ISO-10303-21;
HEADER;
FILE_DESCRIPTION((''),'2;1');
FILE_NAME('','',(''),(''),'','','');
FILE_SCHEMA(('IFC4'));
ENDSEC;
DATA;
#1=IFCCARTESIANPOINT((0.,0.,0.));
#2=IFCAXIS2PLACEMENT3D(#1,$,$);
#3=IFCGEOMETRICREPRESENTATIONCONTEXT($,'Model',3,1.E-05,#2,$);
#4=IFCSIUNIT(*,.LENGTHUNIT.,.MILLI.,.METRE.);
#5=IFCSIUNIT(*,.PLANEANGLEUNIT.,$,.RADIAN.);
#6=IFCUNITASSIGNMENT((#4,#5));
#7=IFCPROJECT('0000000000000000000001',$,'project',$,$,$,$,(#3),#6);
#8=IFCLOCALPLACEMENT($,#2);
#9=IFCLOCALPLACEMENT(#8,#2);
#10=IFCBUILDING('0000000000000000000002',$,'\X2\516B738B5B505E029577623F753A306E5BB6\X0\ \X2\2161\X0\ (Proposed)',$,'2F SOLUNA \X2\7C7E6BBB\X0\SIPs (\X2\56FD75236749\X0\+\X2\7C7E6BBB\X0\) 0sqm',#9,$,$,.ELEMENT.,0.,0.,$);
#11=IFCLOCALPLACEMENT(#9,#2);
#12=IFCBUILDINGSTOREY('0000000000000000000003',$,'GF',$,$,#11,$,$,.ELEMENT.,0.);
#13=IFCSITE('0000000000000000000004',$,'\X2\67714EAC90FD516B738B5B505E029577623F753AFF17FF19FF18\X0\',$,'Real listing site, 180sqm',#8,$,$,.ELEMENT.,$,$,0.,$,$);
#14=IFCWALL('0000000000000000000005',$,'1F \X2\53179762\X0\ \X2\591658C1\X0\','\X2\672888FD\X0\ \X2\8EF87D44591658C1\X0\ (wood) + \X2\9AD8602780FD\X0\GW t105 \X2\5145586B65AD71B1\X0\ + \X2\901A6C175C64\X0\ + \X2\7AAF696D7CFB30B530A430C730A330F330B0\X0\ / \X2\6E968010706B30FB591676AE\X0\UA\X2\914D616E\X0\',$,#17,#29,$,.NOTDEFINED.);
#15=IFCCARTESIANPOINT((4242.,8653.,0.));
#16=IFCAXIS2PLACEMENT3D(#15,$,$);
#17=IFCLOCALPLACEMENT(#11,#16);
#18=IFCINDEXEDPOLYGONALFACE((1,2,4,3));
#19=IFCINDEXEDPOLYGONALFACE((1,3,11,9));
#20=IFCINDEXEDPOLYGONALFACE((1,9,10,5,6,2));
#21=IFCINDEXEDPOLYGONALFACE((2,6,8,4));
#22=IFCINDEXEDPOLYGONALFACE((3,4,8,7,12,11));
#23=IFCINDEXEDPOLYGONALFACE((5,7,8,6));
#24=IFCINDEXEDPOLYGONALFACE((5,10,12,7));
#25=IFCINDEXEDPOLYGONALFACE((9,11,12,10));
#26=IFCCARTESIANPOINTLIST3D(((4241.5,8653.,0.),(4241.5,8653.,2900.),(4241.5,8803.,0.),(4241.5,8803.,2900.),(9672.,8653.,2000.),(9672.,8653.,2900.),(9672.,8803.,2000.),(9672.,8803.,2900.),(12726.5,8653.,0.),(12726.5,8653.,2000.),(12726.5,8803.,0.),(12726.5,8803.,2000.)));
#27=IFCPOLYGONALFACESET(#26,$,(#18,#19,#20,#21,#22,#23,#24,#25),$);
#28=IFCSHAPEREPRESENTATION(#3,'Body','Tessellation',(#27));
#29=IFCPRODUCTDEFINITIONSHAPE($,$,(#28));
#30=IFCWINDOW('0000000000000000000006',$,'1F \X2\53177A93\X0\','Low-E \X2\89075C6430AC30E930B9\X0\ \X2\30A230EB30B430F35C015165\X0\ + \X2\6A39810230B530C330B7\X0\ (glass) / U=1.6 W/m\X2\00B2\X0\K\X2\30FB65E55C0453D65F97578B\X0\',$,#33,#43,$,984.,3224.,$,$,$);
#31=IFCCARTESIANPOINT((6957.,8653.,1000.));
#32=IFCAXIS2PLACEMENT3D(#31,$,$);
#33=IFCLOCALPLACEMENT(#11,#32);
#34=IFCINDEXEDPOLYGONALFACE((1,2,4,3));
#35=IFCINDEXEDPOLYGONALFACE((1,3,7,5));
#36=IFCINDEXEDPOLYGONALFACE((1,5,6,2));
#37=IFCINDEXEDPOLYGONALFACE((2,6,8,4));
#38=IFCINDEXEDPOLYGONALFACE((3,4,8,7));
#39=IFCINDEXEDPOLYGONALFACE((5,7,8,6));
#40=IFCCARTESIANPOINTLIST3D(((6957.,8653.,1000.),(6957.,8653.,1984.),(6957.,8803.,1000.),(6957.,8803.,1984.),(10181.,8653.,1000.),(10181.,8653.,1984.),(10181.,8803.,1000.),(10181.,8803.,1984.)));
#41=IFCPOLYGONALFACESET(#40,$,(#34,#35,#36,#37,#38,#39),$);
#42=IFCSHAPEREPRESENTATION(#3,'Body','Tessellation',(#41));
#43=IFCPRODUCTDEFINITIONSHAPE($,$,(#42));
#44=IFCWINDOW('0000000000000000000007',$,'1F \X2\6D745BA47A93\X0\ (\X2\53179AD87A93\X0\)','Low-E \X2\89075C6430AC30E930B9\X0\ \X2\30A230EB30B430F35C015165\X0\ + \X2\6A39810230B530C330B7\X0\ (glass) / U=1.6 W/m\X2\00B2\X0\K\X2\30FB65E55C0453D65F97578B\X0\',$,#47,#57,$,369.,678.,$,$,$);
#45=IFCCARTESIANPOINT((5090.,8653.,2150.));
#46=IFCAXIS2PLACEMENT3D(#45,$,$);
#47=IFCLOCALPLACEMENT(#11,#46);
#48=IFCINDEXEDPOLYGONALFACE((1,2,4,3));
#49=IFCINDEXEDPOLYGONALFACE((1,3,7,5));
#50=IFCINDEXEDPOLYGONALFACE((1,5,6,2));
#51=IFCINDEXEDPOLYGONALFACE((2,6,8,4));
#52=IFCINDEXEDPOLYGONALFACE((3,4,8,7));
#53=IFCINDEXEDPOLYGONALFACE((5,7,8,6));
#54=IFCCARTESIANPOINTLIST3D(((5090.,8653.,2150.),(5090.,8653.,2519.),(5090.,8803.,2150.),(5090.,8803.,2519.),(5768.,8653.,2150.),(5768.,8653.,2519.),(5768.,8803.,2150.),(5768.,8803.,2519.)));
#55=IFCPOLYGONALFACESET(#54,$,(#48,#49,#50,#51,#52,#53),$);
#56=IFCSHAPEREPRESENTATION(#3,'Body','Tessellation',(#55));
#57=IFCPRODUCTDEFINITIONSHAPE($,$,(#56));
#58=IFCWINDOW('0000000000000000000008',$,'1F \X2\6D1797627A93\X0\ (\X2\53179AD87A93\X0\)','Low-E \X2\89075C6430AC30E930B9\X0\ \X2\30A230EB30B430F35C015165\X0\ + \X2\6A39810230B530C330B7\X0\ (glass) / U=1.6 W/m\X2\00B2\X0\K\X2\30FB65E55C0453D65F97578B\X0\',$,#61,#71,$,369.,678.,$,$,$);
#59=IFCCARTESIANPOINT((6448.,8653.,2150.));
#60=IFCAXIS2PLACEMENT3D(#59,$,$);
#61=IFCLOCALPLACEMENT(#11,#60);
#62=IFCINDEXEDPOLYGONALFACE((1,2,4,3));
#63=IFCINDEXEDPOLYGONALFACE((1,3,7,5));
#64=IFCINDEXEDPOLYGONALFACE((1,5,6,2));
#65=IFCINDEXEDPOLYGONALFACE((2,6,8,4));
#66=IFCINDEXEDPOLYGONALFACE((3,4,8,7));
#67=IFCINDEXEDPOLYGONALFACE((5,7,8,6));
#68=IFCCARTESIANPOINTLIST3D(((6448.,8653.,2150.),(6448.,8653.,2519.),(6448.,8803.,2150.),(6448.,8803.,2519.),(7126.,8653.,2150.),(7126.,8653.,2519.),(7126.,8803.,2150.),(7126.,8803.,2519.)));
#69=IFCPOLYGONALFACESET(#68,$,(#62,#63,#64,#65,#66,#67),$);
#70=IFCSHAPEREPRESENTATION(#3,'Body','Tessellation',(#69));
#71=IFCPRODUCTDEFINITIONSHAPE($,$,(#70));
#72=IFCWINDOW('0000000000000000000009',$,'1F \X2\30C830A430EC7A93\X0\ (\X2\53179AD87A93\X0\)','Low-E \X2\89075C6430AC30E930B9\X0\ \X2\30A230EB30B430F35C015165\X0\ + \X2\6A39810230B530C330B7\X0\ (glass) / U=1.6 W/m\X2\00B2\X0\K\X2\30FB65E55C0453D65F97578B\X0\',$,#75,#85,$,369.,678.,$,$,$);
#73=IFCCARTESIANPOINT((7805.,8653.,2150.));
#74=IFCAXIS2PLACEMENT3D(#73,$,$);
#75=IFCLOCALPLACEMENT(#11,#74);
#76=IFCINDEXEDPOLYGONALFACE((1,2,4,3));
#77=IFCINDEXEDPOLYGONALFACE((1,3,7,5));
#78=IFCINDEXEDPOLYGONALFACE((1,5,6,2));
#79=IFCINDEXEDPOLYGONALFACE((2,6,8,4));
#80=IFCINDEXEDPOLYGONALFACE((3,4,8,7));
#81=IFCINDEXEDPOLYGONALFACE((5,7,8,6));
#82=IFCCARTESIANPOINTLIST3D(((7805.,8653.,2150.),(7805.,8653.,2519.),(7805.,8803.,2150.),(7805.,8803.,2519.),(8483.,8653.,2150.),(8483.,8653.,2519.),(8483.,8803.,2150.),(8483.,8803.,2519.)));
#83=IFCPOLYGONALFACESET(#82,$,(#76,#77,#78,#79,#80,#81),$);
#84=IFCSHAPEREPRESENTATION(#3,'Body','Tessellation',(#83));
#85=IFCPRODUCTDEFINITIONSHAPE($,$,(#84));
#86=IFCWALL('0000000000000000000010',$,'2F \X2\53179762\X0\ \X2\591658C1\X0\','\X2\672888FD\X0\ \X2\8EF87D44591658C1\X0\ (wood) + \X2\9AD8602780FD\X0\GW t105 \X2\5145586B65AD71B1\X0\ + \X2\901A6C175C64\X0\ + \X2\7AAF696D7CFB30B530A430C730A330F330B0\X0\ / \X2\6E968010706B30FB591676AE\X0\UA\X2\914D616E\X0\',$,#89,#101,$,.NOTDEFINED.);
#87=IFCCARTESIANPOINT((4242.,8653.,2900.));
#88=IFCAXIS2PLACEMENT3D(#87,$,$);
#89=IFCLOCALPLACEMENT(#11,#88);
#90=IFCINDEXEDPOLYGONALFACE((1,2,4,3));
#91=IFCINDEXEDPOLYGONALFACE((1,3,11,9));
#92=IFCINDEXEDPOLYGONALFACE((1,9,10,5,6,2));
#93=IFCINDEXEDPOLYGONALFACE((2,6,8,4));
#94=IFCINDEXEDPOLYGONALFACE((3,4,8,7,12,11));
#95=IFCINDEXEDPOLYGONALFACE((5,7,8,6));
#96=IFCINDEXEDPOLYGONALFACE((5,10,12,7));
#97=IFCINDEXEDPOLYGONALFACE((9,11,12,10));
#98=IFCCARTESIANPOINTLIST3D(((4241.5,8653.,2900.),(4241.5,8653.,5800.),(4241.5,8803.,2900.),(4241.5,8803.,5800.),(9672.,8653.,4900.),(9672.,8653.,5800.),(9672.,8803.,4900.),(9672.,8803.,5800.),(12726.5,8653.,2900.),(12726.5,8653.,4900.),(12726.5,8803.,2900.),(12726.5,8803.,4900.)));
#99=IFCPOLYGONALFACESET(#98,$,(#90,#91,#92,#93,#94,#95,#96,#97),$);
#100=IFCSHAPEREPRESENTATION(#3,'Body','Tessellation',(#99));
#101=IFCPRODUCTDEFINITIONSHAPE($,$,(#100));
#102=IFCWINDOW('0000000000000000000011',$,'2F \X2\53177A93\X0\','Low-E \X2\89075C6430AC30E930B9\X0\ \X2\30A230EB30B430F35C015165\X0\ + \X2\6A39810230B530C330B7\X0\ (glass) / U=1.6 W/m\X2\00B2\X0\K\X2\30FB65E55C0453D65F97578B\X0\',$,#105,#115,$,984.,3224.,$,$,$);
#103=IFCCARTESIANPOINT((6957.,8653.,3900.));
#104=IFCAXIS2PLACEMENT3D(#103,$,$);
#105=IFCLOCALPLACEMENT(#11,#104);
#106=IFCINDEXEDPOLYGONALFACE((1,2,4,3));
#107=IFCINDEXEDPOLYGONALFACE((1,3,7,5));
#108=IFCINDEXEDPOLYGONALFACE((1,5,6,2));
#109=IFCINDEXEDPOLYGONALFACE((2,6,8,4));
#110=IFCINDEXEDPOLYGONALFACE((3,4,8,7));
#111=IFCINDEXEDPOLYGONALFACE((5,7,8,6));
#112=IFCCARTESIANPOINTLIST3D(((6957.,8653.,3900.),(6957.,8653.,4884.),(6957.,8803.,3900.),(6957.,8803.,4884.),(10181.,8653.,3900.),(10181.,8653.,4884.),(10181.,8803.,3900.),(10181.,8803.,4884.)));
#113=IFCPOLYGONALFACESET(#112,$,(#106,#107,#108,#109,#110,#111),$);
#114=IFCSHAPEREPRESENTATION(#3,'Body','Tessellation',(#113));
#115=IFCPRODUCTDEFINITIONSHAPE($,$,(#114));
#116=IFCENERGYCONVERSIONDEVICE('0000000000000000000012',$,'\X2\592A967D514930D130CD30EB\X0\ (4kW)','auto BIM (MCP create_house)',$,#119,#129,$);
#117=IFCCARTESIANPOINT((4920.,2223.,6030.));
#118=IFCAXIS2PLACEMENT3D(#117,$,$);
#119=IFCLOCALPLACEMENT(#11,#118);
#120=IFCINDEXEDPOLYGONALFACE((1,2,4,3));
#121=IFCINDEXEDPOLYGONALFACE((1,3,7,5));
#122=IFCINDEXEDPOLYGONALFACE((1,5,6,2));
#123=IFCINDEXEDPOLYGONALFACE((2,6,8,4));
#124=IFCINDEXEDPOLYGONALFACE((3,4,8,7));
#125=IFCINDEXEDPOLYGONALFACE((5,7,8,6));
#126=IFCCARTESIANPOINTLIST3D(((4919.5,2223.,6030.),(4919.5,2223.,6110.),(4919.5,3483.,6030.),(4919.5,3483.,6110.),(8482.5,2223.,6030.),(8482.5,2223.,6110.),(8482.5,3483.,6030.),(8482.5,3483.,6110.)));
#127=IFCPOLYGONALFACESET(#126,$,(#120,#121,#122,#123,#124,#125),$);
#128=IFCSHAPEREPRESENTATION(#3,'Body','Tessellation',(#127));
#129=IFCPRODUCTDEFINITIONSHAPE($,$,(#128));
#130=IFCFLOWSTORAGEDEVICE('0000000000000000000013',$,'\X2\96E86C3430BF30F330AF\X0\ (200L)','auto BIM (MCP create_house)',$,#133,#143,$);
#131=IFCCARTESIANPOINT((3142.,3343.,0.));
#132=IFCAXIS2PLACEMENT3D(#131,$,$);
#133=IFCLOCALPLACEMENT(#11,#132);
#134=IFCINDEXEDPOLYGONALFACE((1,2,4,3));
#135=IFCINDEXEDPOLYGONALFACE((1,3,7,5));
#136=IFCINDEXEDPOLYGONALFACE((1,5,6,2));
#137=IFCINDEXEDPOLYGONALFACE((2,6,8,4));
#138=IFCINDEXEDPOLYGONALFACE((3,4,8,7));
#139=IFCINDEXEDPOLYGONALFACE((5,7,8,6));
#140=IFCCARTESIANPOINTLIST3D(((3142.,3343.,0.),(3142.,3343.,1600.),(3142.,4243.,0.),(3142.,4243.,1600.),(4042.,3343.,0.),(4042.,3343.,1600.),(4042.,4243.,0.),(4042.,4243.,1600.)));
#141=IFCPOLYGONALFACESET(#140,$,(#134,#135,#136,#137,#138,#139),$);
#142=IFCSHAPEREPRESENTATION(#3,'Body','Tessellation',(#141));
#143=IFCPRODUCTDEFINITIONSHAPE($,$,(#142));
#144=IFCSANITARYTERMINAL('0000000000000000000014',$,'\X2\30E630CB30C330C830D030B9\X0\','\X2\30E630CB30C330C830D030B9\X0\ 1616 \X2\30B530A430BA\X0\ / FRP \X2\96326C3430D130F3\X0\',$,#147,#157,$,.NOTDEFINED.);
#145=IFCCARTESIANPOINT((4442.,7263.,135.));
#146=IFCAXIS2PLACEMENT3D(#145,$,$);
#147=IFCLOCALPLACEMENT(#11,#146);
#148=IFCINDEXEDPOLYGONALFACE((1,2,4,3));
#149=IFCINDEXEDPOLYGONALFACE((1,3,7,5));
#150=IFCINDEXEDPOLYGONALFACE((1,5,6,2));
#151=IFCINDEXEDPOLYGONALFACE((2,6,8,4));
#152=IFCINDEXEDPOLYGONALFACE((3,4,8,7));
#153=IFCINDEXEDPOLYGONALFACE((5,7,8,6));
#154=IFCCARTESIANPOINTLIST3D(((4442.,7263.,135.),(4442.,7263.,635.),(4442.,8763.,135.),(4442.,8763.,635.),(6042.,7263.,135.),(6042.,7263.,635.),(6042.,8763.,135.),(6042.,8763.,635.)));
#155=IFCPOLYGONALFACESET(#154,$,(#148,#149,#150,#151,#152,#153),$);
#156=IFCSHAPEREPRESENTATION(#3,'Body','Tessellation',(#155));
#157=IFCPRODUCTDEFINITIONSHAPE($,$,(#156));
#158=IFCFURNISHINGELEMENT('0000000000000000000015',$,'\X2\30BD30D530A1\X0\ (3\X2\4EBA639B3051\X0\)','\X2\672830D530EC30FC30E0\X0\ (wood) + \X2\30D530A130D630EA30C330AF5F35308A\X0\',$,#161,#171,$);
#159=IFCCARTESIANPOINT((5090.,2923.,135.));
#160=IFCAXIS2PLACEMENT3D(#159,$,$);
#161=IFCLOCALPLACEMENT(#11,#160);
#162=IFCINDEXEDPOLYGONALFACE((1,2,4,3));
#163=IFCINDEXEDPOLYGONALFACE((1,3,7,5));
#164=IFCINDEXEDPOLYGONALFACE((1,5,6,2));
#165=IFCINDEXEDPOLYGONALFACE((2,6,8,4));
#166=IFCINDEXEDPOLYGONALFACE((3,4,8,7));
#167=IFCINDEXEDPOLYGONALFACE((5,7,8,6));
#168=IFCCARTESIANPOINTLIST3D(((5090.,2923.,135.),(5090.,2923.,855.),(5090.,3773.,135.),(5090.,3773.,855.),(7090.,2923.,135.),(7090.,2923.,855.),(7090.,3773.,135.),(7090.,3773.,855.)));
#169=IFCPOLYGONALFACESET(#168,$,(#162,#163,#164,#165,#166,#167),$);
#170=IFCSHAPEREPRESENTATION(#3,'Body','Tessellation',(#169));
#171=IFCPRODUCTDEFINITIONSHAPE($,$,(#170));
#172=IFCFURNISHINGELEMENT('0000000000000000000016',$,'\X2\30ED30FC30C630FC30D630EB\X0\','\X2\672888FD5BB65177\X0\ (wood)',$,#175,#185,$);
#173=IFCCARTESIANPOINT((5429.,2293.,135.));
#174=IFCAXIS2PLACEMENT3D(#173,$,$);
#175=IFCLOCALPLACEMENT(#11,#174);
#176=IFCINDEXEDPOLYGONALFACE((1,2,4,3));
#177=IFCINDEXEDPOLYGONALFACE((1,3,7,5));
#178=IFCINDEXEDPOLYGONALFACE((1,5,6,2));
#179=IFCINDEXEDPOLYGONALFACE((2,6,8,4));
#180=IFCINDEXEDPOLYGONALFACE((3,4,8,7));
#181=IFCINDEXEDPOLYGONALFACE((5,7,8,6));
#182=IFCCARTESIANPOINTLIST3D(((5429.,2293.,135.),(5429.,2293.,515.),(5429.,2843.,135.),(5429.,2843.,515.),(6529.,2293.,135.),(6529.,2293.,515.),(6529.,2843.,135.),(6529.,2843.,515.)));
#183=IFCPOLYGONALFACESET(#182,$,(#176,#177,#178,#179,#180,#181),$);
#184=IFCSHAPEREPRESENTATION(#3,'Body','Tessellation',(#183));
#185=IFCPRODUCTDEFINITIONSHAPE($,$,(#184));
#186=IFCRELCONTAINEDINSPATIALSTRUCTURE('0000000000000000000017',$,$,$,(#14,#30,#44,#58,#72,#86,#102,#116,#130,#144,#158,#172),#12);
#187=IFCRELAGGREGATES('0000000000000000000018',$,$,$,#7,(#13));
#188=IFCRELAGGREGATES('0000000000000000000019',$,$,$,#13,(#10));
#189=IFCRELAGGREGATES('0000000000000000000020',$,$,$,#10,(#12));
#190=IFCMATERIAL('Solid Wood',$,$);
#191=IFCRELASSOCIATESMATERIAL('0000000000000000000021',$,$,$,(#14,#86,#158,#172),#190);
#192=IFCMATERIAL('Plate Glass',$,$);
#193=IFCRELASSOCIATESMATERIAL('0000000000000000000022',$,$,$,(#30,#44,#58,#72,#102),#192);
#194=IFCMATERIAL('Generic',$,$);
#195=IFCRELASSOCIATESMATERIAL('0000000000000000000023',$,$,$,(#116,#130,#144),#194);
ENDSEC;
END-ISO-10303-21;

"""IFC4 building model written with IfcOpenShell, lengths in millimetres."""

from ifc_helpers import new_model, si_unit, frame, frame_2d, origin, place, context, project, spatial, rectangle, extrude, material, element, fill, save


model = new_model("IFC4")

# Units and contexts
model_context = context("Model", 3, precision=1e-05, world=origin())
ifc_project = project(units=[si_unit("LENGTHUNIT", "METRE", prefix="MILLI"), si_unit("PLANEANGLEUNIT", "RADIAN")], contexts=[model_context])

# Site, building, storey
site_placement = place(None, origin())
site = spatial("IfcSite", under=ifc_project, at=site_placement, Name="東京都八王子市長房町７９８", ObjectType="Real listing site, 180sqm", CompositionType="ELEMENT", RefElevation=0.0)
building_placement = place(site_placement, origin())
building = spatial("IfcBuilding", under=site, at=building_placement, Name="八王子市長房町の家 Ⅱ (Proposed)", ObjectType="2F SOLUNA 籾殻SIPs (国産杉+籾殻) 0sqm", CompositionType="ELEMENT", ElevationOfRefHeight=0.0, ElevationOfTerrain=0.0)
storey_placement = place(building_placement, origin())
storey = spatial("IfcBuildingStorey", under=building, at=storey_placement, Name="GF", CompositionType="ELEMENT", Elevation=0.0)

# Wall, openings, windows
ifc_material_1 = material(Name="Solid Wood")
wall_1_placement = place(storey_placement, frame((4242.0, 8653.0, 0.0)))
wall_1 = element("IfcWall", 1, at=wall_1_placement, inside=storey, material=ifc_material_1, Name="1F 北面 外壁", Description="木製 軸組外壁 (wood) + 高性能GW t105 充填断熱 + 通気層 + 窯業系サイディング / 準耐火・外皮UA配慮", PredefinedType="NOTDEFINED", context=model_context, shape_type="SweptSolid", body=[
    extrude(rectangle(XDim=8485.0, YDim=150.0, at=frame_2d((4242.0, 75.0))), frame((4242.0, 8653.0, 0.0)), (0.0, 0.0, 1.0), 2900.0),
])
opening_1_placement = place(storey_placement, frame((6957.0, 8653.0, 1000.0)))
opening_1 = element("IfcOpeningElement", 2, at=opening_1_placement, cuts=wall_1, PredefinedType="NOTDEFINED", context=model_context, shape_type="SweptSolid", body=[
    extrude(rectangle(XDim=3224.0, YDim=150.0, at=frame_2d((1612.0, 75.0))), frame((6957.0, 8653.0, 1000.0)), (0.0, 0.0, 1.0), 984.0),
])
opening_2_placement = place(storey_placement, frame((5090.0, 8653.0, 2150.0)))
opening_2 = element("IfcOpeningElement", 3, at=opening_2_placement, cuts=wall_1, PredefinedType="NOTDEFINED", context=model_context, shape_type="SweptSolid", body=[
    extrude(rectangle(XDim=678.0, YDim=150.0, at=frame_2d((339.0, 75.0))), frame((5090.0, 8653.0, 2150.0)), (0.0, 0.0, 1.0), 369.0),
])
opening_3_placement = place(storey_placement, frame((6448.0, 8653.0, 2150.0)))
opening_3 = element("IfcOpeningElement", 4, at=opening_3_placement, cuts=wall_1, PredefinedType="NOTDEFINED", context=model_context, shape_type="SweptSolid", body=[
    extrude(rectangle(XDim=678.0, YDim=150.0, at=frame_2d((339.0, 75.0))), frame((6448.0, 8653.0, 2150.0)), (0.0, 0.0, 1.0), 369.0),
])
opening_4_placement = place(storey_placement, frame((7805.0, 8653.0, 2150.0)))
opening_4 = element("IfcOpeningElement", 5, at=opening_4_placement, cuts=wall_1, PredefinedType="NOTDEFINED", context=model_context, shape_type="SweptSolid", body=[
    extrude(rectangle(XDim=678.0, YDim=150.0, at=frame_2d((339.0, 75.0))), frame((7805.0, 8653.0, 2150.0)), (0.0, 0.0, 1.0), 369.0),
])
ifc_material_2 = material(Name="Plate Glass")
window_1_placement = place(storey_placement, frame((6957.0, 8653.0, 1000.0)))
window_1 = element("IfcWindow", 6, at=window_1_placement, inside=storey, material=ifc_material_2, Name="1F 北窓", Description="Low-E 複層ガラス アルゴン封入 + 樹脂サッシ (glass) / U=1.6 W/m²K・日射取得型", OverallHeight=984.0, OverallWidth=3224.0, context=model_context, shape_type="SweptSolid", body=[
    extrude(rectangle(XDim=3224.0, YDim=150.0, at=frame_2d((1612.0, 75.0))), frame((6957.0, 8653.0, 1000.0)), (0.0, 0.0, 1.0), 984.0),
])
fill(opening_1, window_1)
window_2_placement = place(storey_placement, frame((5090.0, 8653.0, 2150.0)))
window_2 = element("IfcWindow", 7, at=window_2_placement, inside=storey, material=ifc_material_2, Name="1F 浴室窓 (北高窓)", Description="Low-E 複層ガラス アルゴン封入 + 樹脂サッシ (glass) / U=1.6 W/m²K・日射取得型", OverallHeight=369.0, OverallWidth=678.0, context=model_context, shape_type="SweptSolid", body=[
    extrude(rectangle(XDim=678.0, YDim=150.0, at=frame_2d((339.0, 75.0))), frame((5090.0, 8653.0, 2150.0)), (0.0, 0.0, 1.0), 369.0),
])
fill(opening_2, window_2)
window_3_placement = place(storey_placement, frame((6448.0, 8653.0, 2150.0)))
window_3 = element("IfcWindow", 8, at=window_3_placement, inside=storey, material=ifc_material_2, Name="1F 洗面窓 (北高窓)", Description="Low-E 複層ガラス アルゴン封入 + 樹脂サッシ (glass) / U=1.6 W/m²K・日射取得型", OverallHeight=369.0, OverallWidth=678.0, context=model_context, shape_type="SweptSolid", body=[
    extrude(rectangle(XDim=678.0, YDim=150.0, at=frame_2d((339.0, 75.0))), frame((6448.0, 8653.0, 2150.0)), (0.0, 0.0, 1.0), 369.0),
])
fill(opening_3, window_3)
window_4_placement = place(storey_placement, frame((7805.0, 8653.0, 2150.0)))
window_4 = element("IfcWindow", 9, at=window_4_placement, inside=storey, material=ifc_material_2, Name="1F トイレ窓 (北高窓)", Description="Low-E 複層ガラス アルゴン封入 + 樹脂サッシ (glass) / U=1.6 W/m²K・日射取得型", OverallHeight=369.0, OverallWidth=678.0, context=model_context, shape_type="SweptSolid", body=[
    extrude(rectangle(XDim=678.0, YDim=150.0, at=frame_2d((339.0, 75.0))), frame((7805.0, 8653.0, 2150.0)), (0.0, 0.0, 1.0), 369.0),
])
fill(opening_4, window_4)

# Wall, opening, window
wall_2_placement = place(storey_placement, frame((4242.0, 8653.0, 2900.0)))
wall_2 = element("IfcWall", 10, at=wall_2_placement, inside=storey, material=ifc_material_1, Name="2F 北面 外壁", Description="木製 軸組外壁 (wood) + 高性能GW t105 充填断熱 + 通気層 + 窯業系サイディング / 準耐火・外皮UA配慮", PredefinedType="NOTDEFINED", context=model_context, shape_type="SweptSolid", body=[
    extrude(rectangle(XDim=8485.0, YDim=150.0, at=frame_2d((4242.0, 75.0))), frame((4242.0, 8653.0, 2900.0)), (0.0, 0.0, 1.0), 2900.0),
])
opening_5_placement = place(storey_placement, frame((6957.0, 8653.0, 3900.0)))
opening_5 = element("IfcOpeningElement", 11, at=opening_5_placement, cuts=wall_2, PredefinedType="NOTDEFINED", context=model_context, shape_type="SweptSolid", body=[
    extrude(rectangle(XDim=3224.0, YDim=150.0, at=frame_2d((1612.0, 75.0))), frame((6957.0, 8653.0, 3900.0)), (0.0, 0.0, 1.0), 984.0),
])
window_5_placement = place(storey_placement, frame((6957.0, 8653.0, 3900.0)))
window_5 = element("IfcWindow", 12, at=window_5_placement, inside=storey, material=ifc_material_2, Name="2F 北窓", Description="Low-E 複層ガラス アルゴン封入 + 樹脂サッシ (glass) / U=1.6 W/m²K・日射取得型", OverallHeight=984.0, OverallWidth=3224.0, context=model_context, shape_type="SweptSolid", body=[
    extrude(rectangle(XDim=3224.0, YDim=150.0, at=frame_2d((1612.0, 75.0))), frame((6957.0, 8653.0, 3900.0)), (0.0, 0.0, 1.0), 984.0),
])
fill(opening_5, window_5)

# Energy conversion device
ifc_material_3 = material(Name="Generic")
energy_conversion_device_placement = place(storey_placement, frame((4920.0, 2223.0, 6030.0)))
element("IfcEnergyConversionDevice", 13, at=energy_conversion_device_placement, inside=storey, material=ifc_material_3, Name="太陽光パネル (4kW)", Description="auto BIM (MCP create_house)", context=model_context, shape_type="SweptSolid", body=[
    extrude(rectangle(XDim=3563.0, YDim=1260.0, at=frame_2d((1781.0, 630.0))), frame((4920.0, 2223.0, 6030.0)), (0.0, 0.0, 1.0), 80.0),
])

# Flow storage device
flow_storage_device_placement = place(storey_placement, frame((3142.0, 3343.0, 0.0)))
element("IfcFlowStorageDevice", 14, at=flow_storage_device_placement, inside=storey, material=ifc_material_3, Name="雨水タンク (200L)", Description="auto BIM (MCP create_house)", context=model_context, shape_type="SweptSolid", body=[
    extrude(rectangle(XDim=900.0, YDim=900.0, at=frame_2d((450.0, 450.0))), frame((3142.0, 3343.0, 0.0)), (0.0, 0.0, 1.0), 1600.0),
])

# Sanitary terminal
sanitary_terminal_placement = place(storey_placement, frame((4442.0, 7263.0, 135.0)))
element("IfcSanitaryTerminal", 15, at=sanitary_terminal_placement, inside=storey, material=ifc_material_3, Name="ユニットバス", Description="ユニットバス 1616 サイズ / FRP 防水パン", PredefinedType="NOTDEFINED", context=model_context, shape_type="SweptSolid", body=[
    extrude(rectangle(XDim=1600.0, YDim=1500.0, at=frame_2d((800.0, 750.0))), frame((4442.0, 7263.0, 135.0)), (0.0, 0.0, 1.0), 500.0),
])

# Furnishing elements
furnishing_1_placement = place(storey_placement, frame((5090.0, 2923.0, 135.0)))
element("IfcFurnishingElement", 16, at=furnishing_1_placement, inside=storey, material=ifc_material_1, Name="ソファ (3人掛け)", Description="木フレーム (wood) + ファブリック張り", context=model_context, shape_type="SweptSolid", body=[
    extrude(rectangle(XDim=2000.0, YDim=850.0, at=frame_2d((1000.0, 425.0))), frame((5090.0, 2923.0, 135.0)), (0.0, 0.0, 1.0), 720.0),
])
furnishing_2_placement = place(storey_placement, frame((5429.0, 2293.0, 135.0)))
element("IfcFurnishingElement", 17, at=furnishing_2_placement, inside=storey, material=ifc_material_1, Name="ローテーブル", Description="木製家具 (wood)", context=model_context, shape_type="SweptSolid", body=[
    extrude(rectangle(XDim=1100.0, YDim=550.0, at=frame_2d((550.0, 275.0))), frame((5429.0, 2293.0, 135.0)), (0.0, 0.0, 1.0), 380.0),
])

save(model, "model.ifc")
